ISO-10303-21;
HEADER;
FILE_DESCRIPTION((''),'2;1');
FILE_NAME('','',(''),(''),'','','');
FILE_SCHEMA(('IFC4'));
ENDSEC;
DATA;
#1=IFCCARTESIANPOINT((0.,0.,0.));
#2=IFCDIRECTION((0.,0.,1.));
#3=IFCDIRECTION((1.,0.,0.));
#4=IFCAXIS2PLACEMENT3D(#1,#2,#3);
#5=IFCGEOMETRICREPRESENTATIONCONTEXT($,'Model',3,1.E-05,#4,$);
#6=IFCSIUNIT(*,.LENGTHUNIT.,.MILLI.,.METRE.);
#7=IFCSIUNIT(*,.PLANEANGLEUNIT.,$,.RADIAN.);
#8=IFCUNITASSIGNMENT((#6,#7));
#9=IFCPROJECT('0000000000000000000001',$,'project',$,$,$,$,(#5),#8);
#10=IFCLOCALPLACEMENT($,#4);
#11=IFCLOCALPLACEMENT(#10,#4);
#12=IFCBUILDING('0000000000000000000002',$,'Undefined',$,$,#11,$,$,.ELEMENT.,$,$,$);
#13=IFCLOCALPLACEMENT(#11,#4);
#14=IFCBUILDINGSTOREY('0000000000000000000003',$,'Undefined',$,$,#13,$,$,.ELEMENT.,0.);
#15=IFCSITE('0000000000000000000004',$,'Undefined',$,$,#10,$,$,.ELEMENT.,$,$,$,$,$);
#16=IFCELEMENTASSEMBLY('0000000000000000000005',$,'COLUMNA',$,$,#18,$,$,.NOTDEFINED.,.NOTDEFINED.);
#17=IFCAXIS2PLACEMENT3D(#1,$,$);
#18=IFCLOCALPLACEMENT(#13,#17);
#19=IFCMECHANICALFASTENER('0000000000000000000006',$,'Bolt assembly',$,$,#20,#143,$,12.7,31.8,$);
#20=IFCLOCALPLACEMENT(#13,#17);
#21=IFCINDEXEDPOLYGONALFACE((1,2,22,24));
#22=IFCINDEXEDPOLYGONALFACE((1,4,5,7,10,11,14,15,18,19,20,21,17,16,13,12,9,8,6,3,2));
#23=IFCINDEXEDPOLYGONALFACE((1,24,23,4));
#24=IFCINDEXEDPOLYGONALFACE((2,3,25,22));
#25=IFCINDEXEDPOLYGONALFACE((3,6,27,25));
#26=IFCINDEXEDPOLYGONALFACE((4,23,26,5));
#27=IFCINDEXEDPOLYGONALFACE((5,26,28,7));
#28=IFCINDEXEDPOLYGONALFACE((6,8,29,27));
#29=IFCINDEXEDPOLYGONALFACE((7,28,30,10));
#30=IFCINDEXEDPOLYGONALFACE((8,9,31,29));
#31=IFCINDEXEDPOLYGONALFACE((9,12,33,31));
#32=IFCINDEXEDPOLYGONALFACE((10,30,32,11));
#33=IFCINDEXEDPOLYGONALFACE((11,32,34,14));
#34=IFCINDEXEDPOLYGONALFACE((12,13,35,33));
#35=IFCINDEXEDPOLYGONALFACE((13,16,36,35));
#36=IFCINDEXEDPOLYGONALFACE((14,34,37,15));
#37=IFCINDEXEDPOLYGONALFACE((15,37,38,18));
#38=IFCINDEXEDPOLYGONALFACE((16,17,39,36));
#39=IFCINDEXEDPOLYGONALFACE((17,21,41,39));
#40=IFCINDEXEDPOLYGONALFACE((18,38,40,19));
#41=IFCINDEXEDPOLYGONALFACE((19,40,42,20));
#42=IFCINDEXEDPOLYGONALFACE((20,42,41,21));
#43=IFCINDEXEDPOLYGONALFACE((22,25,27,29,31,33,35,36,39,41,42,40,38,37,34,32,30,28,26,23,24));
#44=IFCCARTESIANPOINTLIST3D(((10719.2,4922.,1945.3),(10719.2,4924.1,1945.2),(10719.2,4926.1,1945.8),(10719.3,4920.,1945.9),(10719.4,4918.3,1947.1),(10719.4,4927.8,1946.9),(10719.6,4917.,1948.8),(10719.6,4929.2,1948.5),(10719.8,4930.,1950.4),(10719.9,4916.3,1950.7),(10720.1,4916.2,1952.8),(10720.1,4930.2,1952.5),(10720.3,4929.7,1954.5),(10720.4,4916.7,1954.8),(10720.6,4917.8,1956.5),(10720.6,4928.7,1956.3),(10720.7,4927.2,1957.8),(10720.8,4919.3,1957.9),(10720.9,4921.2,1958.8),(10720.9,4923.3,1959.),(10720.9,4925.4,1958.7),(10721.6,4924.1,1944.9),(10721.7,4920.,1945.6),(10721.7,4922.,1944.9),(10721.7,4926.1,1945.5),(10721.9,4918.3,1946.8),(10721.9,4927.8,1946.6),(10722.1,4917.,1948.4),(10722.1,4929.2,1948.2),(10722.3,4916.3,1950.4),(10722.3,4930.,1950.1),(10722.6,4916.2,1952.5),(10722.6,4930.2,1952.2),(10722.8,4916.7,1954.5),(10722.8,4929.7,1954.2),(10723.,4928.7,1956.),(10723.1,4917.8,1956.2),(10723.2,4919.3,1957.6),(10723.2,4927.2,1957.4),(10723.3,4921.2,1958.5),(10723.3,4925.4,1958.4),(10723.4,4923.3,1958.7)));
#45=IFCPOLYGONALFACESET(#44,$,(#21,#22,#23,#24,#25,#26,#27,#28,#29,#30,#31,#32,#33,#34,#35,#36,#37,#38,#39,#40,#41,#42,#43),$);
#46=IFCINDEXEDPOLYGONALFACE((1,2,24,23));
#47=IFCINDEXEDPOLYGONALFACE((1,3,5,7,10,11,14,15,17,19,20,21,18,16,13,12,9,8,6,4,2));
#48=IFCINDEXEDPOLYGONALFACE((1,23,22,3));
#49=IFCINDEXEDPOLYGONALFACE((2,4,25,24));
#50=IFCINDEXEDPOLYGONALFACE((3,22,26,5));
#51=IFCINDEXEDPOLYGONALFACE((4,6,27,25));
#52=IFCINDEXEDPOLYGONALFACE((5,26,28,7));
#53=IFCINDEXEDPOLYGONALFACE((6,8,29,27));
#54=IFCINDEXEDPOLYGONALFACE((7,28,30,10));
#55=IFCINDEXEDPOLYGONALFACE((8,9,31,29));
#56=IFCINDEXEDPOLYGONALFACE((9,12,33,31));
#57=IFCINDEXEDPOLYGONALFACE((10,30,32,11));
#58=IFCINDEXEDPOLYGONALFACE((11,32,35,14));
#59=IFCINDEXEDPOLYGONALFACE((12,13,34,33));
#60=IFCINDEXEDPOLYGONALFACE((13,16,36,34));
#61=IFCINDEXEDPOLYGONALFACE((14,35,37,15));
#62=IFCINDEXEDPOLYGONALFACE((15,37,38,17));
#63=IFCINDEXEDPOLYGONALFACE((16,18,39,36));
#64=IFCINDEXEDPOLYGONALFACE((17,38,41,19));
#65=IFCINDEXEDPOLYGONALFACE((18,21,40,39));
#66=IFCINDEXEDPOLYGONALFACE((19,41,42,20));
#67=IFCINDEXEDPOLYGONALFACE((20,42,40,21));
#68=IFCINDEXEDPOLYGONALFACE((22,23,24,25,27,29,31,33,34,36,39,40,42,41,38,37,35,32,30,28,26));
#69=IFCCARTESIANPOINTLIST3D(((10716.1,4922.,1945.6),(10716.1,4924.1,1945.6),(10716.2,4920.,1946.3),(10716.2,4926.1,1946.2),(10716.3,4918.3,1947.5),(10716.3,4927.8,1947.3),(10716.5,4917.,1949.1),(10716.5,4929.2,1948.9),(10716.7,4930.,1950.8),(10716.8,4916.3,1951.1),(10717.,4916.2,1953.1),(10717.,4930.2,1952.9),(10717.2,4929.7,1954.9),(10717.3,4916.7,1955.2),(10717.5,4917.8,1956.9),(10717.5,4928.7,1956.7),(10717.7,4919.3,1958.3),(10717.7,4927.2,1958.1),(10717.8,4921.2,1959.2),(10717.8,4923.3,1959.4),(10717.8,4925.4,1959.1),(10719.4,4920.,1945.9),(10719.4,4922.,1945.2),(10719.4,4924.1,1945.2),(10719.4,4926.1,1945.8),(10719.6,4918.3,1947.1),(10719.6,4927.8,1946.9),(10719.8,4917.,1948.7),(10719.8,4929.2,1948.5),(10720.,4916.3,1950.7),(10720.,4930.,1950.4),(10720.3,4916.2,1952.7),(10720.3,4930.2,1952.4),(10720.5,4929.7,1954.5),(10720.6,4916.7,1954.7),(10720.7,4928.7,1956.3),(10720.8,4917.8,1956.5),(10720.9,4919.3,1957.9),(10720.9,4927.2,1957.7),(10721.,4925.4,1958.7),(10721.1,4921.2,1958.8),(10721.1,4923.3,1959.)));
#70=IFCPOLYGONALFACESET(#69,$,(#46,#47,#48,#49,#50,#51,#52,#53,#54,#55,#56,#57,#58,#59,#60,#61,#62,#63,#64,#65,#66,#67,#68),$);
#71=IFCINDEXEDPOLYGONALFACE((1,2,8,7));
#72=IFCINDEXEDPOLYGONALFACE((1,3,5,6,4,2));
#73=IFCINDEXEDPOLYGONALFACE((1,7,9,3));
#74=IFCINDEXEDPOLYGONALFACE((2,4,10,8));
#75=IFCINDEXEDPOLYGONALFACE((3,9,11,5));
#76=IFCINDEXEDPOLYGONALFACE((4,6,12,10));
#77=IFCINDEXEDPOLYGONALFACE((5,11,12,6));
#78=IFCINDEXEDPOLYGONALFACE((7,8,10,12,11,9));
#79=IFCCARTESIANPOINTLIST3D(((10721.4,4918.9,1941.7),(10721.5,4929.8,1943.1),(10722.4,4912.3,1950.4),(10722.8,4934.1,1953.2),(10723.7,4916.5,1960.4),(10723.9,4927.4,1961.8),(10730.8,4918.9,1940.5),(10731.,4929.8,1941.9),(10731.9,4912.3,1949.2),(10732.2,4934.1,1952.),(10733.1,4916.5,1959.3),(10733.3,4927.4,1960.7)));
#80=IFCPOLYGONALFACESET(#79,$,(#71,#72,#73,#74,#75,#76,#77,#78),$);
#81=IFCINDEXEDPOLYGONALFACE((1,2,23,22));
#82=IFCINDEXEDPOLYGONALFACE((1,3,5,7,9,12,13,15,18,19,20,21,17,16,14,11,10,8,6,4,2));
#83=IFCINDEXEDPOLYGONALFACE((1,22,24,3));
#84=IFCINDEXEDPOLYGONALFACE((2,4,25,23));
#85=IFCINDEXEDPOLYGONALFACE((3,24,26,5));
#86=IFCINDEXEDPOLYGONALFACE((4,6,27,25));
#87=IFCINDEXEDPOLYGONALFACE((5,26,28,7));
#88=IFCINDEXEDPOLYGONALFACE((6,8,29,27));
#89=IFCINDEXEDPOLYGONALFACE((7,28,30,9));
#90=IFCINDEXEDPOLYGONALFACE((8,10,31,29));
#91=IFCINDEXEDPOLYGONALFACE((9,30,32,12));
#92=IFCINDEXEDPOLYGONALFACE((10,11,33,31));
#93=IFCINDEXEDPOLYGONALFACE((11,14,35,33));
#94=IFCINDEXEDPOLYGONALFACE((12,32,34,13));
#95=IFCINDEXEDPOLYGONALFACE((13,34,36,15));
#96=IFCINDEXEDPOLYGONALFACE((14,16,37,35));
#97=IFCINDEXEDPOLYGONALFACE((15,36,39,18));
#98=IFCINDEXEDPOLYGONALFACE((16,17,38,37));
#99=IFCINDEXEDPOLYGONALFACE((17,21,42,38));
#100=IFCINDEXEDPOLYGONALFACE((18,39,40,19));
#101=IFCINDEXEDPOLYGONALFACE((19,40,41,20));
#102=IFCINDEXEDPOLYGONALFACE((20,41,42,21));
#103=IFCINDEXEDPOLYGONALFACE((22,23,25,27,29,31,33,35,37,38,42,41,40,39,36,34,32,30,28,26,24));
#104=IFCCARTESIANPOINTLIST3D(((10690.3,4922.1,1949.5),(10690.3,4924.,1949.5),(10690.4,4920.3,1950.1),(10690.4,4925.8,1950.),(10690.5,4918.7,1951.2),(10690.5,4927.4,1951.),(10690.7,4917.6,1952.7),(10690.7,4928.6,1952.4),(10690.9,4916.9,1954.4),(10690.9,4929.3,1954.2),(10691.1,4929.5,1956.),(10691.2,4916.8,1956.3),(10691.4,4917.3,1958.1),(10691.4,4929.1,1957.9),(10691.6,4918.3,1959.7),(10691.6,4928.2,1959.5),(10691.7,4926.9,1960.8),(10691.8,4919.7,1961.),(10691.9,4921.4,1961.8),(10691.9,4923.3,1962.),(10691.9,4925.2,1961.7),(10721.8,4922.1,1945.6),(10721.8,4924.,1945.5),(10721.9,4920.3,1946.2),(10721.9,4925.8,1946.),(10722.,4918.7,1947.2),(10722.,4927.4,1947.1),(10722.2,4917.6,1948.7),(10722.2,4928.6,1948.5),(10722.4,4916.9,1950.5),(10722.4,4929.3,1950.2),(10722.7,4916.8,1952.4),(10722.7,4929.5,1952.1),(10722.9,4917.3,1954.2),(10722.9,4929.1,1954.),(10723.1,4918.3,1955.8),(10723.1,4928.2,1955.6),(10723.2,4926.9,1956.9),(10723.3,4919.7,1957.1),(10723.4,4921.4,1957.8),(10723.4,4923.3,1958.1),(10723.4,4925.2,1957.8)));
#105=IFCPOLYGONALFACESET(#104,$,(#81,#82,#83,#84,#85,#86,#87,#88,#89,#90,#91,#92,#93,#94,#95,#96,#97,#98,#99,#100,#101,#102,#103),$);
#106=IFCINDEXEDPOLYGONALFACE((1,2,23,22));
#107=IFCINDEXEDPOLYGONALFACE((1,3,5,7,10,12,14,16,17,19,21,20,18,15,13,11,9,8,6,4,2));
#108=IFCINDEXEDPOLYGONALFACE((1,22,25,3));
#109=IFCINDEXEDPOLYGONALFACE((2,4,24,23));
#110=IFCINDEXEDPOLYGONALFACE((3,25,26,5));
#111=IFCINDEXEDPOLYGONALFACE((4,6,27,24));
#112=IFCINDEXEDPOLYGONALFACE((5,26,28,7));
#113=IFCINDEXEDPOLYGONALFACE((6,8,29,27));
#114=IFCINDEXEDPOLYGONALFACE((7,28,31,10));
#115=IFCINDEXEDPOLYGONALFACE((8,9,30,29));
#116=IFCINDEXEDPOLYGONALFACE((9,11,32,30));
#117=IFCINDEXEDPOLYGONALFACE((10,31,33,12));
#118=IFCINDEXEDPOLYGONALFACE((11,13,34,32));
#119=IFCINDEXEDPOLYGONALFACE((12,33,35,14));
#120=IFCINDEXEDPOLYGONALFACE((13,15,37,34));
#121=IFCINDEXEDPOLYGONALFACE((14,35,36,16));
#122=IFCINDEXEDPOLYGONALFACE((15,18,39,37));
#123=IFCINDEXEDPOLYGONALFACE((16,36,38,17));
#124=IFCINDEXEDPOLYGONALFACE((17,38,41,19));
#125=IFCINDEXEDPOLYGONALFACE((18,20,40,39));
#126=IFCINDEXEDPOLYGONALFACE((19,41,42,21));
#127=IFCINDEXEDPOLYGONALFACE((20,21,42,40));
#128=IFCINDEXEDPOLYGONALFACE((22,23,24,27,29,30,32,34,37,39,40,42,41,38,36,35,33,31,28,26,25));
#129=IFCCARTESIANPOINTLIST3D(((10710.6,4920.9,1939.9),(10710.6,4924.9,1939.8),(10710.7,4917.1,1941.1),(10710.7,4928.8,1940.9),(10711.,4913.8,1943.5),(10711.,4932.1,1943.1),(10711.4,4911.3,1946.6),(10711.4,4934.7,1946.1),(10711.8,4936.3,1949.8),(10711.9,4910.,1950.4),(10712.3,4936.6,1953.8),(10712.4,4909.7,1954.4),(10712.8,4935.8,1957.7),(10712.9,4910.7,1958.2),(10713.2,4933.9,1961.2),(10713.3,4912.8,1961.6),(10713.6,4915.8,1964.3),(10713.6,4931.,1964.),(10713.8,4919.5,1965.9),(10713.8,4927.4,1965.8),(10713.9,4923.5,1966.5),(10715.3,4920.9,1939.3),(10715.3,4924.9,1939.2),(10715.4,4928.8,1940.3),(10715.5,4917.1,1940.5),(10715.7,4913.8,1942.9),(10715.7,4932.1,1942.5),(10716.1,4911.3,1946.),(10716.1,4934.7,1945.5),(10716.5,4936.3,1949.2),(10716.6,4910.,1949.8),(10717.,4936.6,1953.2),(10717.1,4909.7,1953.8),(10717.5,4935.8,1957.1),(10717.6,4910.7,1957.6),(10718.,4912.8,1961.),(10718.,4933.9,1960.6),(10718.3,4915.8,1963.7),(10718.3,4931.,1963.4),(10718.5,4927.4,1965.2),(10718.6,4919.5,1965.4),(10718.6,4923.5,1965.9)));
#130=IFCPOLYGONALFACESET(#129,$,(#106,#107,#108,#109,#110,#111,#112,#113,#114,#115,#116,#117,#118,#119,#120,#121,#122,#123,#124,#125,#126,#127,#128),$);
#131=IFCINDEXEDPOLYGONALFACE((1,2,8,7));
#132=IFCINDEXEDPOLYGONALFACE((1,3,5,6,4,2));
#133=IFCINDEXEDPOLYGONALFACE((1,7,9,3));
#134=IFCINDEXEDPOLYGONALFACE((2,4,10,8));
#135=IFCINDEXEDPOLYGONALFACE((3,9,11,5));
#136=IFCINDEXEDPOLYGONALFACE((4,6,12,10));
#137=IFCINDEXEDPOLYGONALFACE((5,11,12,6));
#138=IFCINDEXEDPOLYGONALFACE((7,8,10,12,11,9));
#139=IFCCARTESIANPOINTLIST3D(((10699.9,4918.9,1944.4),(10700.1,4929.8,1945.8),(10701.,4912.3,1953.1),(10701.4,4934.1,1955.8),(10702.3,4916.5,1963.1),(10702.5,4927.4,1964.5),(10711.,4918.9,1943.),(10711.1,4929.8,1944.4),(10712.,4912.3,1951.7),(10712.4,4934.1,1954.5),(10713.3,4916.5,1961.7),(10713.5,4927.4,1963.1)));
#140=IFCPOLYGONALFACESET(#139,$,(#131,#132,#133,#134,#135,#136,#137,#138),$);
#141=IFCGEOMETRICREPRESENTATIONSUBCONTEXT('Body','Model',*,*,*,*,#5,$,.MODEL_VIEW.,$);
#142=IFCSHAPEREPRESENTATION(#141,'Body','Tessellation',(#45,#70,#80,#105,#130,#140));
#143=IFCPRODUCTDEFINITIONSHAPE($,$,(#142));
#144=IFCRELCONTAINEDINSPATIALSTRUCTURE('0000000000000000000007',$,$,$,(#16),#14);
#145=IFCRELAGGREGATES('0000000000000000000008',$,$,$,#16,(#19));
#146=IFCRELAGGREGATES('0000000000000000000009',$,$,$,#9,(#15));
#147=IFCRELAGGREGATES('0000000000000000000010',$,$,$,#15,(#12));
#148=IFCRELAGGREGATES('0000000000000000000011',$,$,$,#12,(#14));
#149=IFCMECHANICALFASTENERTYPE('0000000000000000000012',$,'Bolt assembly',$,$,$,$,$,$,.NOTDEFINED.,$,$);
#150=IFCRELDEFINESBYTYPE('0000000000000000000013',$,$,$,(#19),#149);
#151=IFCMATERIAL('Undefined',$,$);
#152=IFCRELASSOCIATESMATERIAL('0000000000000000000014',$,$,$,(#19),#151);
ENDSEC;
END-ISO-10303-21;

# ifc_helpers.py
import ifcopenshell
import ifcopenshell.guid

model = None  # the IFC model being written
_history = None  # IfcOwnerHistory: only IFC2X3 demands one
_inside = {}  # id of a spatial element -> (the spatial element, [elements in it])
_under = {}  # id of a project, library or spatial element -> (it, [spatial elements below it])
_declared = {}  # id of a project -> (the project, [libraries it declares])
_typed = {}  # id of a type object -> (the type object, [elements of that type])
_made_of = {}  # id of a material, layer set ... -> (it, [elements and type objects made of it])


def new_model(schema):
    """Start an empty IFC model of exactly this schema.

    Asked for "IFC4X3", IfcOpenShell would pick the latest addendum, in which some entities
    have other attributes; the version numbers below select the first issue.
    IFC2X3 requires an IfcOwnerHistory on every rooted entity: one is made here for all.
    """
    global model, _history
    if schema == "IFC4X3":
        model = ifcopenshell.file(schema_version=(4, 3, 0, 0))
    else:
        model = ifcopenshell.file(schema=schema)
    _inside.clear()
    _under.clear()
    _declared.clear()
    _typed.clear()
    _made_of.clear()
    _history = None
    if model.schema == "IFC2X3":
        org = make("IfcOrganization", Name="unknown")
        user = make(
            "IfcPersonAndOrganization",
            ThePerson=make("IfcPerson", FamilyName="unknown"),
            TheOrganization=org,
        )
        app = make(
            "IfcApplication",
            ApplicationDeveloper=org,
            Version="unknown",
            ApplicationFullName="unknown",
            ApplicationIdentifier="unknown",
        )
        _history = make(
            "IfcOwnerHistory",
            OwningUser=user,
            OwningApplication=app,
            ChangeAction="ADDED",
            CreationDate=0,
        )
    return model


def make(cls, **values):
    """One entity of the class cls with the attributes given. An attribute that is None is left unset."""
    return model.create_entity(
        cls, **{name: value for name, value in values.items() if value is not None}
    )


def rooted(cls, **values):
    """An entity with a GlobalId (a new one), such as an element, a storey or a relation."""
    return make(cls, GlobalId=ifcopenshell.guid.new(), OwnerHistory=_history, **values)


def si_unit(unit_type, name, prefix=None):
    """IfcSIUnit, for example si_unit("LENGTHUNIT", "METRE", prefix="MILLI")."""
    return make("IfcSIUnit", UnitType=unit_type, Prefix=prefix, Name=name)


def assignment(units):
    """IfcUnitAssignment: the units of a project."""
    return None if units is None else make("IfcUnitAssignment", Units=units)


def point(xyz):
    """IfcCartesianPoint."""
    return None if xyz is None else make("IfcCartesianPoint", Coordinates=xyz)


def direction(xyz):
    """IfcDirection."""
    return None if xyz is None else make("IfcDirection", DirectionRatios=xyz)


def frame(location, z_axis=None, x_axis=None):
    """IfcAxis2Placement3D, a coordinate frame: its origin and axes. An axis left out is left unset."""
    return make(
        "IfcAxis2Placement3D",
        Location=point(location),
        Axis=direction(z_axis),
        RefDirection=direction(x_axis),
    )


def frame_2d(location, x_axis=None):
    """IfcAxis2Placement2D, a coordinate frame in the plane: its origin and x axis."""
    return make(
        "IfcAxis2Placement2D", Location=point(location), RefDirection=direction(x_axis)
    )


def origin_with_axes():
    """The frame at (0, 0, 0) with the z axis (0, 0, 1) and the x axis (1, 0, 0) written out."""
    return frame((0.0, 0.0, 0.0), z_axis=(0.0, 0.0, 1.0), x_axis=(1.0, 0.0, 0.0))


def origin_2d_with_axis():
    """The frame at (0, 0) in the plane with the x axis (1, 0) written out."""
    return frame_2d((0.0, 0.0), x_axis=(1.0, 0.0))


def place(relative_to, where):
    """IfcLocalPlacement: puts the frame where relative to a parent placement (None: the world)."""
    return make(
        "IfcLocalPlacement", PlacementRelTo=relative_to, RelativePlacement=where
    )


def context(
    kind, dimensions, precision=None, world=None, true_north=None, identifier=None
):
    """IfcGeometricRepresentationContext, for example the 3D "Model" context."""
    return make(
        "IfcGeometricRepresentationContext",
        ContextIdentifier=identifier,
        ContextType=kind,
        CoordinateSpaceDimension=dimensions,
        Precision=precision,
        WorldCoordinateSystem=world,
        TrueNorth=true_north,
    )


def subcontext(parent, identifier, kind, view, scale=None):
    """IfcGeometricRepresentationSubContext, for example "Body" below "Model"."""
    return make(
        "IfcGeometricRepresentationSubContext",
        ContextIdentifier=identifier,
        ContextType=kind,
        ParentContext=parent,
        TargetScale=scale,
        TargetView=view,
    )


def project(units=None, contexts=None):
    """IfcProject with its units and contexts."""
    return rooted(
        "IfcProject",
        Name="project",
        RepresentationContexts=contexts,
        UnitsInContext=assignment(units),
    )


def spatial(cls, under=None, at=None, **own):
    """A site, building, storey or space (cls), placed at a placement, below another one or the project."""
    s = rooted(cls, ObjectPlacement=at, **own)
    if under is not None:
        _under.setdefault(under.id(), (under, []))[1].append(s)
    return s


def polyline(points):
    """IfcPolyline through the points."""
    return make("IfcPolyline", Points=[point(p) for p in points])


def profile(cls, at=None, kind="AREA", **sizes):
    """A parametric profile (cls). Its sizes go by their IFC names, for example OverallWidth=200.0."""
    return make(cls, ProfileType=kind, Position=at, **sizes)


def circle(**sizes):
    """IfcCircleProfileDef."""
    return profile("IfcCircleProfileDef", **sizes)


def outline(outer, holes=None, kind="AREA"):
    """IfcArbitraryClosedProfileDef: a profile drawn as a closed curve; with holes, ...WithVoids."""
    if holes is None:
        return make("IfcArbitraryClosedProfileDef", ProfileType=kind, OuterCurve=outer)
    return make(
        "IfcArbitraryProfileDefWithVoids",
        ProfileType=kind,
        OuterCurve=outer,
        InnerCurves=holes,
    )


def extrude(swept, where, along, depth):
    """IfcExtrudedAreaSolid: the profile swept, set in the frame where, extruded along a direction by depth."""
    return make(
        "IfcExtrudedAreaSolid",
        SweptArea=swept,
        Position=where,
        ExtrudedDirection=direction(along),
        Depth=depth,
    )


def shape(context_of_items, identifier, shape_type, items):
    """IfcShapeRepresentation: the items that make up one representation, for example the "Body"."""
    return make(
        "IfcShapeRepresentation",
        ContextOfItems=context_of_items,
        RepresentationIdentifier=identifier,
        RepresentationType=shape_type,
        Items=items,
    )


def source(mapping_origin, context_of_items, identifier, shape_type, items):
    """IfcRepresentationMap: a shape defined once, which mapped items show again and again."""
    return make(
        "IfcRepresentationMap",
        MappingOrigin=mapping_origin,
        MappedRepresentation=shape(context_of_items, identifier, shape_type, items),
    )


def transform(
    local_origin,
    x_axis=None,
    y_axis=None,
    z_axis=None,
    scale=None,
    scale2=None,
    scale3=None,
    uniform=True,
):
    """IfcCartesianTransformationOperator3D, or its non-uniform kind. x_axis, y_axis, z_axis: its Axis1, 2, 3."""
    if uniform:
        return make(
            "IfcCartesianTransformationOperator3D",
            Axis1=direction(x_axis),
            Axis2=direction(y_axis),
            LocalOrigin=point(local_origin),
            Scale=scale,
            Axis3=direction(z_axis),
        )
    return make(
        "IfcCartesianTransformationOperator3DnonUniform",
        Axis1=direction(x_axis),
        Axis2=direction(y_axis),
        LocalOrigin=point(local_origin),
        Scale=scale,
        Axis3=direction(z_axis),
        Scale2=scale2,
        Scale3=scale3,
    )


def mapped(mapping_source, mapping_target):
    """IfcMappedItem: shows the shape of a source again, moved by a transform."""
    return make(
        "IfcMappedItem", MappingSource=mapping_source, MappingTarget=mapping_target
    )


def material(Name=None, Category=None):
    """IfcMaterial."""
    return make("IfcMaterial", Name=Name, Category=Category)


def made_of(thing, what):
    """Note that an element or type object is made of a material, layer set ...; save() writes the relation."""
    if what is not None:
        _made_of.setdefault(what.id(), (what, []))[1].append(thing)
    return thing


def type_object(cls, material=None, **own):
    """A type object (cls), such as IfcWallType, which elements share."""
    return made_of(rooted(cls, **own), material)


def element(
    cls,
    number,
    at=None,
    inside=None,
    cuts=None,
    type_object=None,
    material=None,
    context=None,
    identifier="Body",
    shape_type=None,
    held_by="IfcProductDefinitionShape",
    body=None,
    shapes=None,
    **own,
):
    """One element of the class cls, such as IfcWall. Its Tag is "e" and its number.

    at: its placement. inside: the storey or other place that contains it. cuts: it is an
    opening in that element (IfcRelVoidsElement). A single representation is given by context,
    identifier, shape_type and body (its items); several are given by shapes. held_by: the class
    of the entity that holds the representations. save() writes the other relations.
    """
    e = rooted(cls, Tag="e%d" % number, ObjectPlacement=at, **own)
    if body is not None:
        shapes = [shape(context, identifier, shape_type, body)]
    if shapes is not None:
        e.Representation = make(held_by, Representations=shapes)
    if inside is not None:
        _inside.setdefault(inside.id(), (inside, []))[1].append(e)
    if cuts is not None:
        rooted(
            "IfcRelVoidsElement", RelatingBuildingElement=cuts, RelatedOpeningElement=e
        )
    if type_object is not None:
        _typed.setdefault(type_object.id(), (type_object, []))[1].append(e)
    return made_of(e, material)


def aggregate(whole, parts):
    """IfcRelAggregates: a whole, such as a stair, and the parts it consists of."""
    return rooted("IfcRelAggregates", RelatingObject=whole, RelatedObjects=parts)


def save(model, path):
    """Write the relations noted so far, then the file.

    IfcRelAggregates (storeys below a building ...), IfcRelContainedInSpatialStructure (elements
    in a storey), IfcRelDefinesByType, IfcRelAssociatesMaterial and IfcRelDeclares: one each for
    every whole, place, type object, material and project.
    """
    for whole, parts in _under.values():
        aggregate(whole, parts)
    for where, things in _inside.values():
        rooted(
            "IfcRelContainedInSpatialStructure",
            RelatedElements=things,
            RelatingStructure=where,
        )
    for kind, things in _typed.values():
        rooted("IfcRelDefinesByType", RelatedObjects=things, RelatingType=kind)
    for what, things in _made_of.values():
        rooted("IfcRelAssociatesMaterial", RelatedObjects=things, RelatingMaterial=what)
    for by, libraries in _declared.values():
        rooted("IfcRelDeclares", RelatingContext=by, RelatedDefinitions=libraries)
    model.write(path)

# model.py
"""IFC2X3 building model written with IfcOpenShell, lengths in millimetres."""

from ifc_helpers import new_model, si_unit, frame, origin_with_axes, origin_2d_with_axis, place, context, subcontext, project, spatial, polyline, circle, outline, extrude, source, transform, mapped, material, type_object, element, aggregate, save


model = new_model("IFC2X3")

# Units and contexts
model_context = context("Model", 3, precision=1e-05, world=origin_with_axes())
body_context = subcontext(model_context, "Body", "Model", "MODEL_VIEW")
ifc_project = project(units=[si_unit("LENGTHUNIT", "METRE", prefix="MILLI"), si_unit("PLANEANGLEUNIT", "RADIAN")], contexts=[model_context])

# Site, building, storey
site_placement = place(None, origin_with_axes())
site = spatial("IfcSite", under=ifc_project, at=site_placement, Name="Undefined", CompositionType="ELEMENT")
building_placement = place(site_placement, origin_with_axes())
building = spatial("IfcBuilding", under=site, at=building_placement, Name="Undefined", CompositionType="ELEMENT")
storey_placement = place(building_placement, origin_with_axes())
storey = spatial("IfcBuildingStorey", under=building, at=storey_placement, Name="Undefined", CompositionType="ELEMENT", Elevation=0.0)

# Element assembly
assembly_1_placement = place(storey_placement, origin_with_axes())
assembly_1 = element("IfcElementAssembly", 1, at=assembly_1_placement, inside=storey, Name="COLUMNA", AssemblyPlace="NOTDEFINED", PredefinedType="NOTDEFINED")

# Shared definitions
ifc_material_1 = material(Name="Undefined")
mechanical_fastener_type = type_object("IfcMechanicalFastenerType", Name="Bolt assembly")

# Mechanical fastener
shared_shape_1 = source(origin_with_axes(), body_context, "Body", "SweptSolid", [
    extrude(circle(Radius=7.0, at=origin_2d_with_axis()), frame((0.0, -2.4, 0.0), z_axis=(0.0, 1.0, 0.0), x_axis=(1.0, 0.0, 0.0)), (0.0, 0.0, 1.0), 2.5),
    extrude(circle(Radius=7.0, at=origin_2d_with_axis()), frame((0.0, -0.1, 0.0), z_axis=(0.0, 1.0, 0.0), x_axis=(1.0, 0.0, 0.0)), (0.0, 0.0, 1.0), 3.3),
    extrude(outline(polyline([(9.5, -5.5), (9.5, 5.5), (0.0, 11.0), (-9.5, 5.5), (-9.5, -5.5), (0.0, -11.0), (9.5, -5.5)])), frame((0.0, -12.0, 0.0), z_axis=(0.0, 1.0, 0.0), x_axis=(1.0, 0.0, 0.0)), (0.0, 0.0, 1.0), 9.5),
    extrude(circle(Radius=6.3, at=origin_2d_with_axis()), frame((0.0, -2.5, 0.0), z_axis=(0.0, 1.0, 0.0), x_axis=(1.0, 0.0, 0.0)), (0.0, 0.0, 1.0), 31.8),
    extrude(circle(Radius=13.5, at=origin_2d_with_axis()), frame((0.0, 3.2, 0.0), z_axis=(0.0, 1.0, 0.0), x_axis=(1.0, 0.0, 0.0)), (0.0, 0.0, 1.0), 4.8),
    extrude(outline(polyline([(9.5, -5.5), (9.5, 5.5), (0.0, 11.0), (-9.5, 5.5), (-9.5, -5.5), (0.0, -11.0), (9.5, -5.5)])), frame((0.0, 8.0, 0.0), z_axis=(0.0, 1.0, 0.0), x_axis=(1.0, 0.0, 0.0)), (0.0, 0.0, 1.0), 11.1),
])
mechanical_fastener_1_placement = place(assembly_1_placement, frame((10720.1, 4923.2, 1952.1), z_axis=(0.098611, -0.606774, 0.788734), x_axis=(0.075276, 0.794875, 0.602086)))
mechanical_fastener_1 = element("IfcMechanicalFastener", 2, at=mechanical_fastener_1_placement, type_object=mechanical_fastener_type, material=ifc_material_1, Name="Bolt assembly", NominalDiameter=12.7, NominalLength=31.8, context=body_context, shape_type="MappedRepresentation", body=[
    mapped(shared_shape_1, transform((0.0, 0.0, 0.0))),
])
aggregate(assembly_1, [mechanical_fastener_1])

save(model, "model.ifc")
